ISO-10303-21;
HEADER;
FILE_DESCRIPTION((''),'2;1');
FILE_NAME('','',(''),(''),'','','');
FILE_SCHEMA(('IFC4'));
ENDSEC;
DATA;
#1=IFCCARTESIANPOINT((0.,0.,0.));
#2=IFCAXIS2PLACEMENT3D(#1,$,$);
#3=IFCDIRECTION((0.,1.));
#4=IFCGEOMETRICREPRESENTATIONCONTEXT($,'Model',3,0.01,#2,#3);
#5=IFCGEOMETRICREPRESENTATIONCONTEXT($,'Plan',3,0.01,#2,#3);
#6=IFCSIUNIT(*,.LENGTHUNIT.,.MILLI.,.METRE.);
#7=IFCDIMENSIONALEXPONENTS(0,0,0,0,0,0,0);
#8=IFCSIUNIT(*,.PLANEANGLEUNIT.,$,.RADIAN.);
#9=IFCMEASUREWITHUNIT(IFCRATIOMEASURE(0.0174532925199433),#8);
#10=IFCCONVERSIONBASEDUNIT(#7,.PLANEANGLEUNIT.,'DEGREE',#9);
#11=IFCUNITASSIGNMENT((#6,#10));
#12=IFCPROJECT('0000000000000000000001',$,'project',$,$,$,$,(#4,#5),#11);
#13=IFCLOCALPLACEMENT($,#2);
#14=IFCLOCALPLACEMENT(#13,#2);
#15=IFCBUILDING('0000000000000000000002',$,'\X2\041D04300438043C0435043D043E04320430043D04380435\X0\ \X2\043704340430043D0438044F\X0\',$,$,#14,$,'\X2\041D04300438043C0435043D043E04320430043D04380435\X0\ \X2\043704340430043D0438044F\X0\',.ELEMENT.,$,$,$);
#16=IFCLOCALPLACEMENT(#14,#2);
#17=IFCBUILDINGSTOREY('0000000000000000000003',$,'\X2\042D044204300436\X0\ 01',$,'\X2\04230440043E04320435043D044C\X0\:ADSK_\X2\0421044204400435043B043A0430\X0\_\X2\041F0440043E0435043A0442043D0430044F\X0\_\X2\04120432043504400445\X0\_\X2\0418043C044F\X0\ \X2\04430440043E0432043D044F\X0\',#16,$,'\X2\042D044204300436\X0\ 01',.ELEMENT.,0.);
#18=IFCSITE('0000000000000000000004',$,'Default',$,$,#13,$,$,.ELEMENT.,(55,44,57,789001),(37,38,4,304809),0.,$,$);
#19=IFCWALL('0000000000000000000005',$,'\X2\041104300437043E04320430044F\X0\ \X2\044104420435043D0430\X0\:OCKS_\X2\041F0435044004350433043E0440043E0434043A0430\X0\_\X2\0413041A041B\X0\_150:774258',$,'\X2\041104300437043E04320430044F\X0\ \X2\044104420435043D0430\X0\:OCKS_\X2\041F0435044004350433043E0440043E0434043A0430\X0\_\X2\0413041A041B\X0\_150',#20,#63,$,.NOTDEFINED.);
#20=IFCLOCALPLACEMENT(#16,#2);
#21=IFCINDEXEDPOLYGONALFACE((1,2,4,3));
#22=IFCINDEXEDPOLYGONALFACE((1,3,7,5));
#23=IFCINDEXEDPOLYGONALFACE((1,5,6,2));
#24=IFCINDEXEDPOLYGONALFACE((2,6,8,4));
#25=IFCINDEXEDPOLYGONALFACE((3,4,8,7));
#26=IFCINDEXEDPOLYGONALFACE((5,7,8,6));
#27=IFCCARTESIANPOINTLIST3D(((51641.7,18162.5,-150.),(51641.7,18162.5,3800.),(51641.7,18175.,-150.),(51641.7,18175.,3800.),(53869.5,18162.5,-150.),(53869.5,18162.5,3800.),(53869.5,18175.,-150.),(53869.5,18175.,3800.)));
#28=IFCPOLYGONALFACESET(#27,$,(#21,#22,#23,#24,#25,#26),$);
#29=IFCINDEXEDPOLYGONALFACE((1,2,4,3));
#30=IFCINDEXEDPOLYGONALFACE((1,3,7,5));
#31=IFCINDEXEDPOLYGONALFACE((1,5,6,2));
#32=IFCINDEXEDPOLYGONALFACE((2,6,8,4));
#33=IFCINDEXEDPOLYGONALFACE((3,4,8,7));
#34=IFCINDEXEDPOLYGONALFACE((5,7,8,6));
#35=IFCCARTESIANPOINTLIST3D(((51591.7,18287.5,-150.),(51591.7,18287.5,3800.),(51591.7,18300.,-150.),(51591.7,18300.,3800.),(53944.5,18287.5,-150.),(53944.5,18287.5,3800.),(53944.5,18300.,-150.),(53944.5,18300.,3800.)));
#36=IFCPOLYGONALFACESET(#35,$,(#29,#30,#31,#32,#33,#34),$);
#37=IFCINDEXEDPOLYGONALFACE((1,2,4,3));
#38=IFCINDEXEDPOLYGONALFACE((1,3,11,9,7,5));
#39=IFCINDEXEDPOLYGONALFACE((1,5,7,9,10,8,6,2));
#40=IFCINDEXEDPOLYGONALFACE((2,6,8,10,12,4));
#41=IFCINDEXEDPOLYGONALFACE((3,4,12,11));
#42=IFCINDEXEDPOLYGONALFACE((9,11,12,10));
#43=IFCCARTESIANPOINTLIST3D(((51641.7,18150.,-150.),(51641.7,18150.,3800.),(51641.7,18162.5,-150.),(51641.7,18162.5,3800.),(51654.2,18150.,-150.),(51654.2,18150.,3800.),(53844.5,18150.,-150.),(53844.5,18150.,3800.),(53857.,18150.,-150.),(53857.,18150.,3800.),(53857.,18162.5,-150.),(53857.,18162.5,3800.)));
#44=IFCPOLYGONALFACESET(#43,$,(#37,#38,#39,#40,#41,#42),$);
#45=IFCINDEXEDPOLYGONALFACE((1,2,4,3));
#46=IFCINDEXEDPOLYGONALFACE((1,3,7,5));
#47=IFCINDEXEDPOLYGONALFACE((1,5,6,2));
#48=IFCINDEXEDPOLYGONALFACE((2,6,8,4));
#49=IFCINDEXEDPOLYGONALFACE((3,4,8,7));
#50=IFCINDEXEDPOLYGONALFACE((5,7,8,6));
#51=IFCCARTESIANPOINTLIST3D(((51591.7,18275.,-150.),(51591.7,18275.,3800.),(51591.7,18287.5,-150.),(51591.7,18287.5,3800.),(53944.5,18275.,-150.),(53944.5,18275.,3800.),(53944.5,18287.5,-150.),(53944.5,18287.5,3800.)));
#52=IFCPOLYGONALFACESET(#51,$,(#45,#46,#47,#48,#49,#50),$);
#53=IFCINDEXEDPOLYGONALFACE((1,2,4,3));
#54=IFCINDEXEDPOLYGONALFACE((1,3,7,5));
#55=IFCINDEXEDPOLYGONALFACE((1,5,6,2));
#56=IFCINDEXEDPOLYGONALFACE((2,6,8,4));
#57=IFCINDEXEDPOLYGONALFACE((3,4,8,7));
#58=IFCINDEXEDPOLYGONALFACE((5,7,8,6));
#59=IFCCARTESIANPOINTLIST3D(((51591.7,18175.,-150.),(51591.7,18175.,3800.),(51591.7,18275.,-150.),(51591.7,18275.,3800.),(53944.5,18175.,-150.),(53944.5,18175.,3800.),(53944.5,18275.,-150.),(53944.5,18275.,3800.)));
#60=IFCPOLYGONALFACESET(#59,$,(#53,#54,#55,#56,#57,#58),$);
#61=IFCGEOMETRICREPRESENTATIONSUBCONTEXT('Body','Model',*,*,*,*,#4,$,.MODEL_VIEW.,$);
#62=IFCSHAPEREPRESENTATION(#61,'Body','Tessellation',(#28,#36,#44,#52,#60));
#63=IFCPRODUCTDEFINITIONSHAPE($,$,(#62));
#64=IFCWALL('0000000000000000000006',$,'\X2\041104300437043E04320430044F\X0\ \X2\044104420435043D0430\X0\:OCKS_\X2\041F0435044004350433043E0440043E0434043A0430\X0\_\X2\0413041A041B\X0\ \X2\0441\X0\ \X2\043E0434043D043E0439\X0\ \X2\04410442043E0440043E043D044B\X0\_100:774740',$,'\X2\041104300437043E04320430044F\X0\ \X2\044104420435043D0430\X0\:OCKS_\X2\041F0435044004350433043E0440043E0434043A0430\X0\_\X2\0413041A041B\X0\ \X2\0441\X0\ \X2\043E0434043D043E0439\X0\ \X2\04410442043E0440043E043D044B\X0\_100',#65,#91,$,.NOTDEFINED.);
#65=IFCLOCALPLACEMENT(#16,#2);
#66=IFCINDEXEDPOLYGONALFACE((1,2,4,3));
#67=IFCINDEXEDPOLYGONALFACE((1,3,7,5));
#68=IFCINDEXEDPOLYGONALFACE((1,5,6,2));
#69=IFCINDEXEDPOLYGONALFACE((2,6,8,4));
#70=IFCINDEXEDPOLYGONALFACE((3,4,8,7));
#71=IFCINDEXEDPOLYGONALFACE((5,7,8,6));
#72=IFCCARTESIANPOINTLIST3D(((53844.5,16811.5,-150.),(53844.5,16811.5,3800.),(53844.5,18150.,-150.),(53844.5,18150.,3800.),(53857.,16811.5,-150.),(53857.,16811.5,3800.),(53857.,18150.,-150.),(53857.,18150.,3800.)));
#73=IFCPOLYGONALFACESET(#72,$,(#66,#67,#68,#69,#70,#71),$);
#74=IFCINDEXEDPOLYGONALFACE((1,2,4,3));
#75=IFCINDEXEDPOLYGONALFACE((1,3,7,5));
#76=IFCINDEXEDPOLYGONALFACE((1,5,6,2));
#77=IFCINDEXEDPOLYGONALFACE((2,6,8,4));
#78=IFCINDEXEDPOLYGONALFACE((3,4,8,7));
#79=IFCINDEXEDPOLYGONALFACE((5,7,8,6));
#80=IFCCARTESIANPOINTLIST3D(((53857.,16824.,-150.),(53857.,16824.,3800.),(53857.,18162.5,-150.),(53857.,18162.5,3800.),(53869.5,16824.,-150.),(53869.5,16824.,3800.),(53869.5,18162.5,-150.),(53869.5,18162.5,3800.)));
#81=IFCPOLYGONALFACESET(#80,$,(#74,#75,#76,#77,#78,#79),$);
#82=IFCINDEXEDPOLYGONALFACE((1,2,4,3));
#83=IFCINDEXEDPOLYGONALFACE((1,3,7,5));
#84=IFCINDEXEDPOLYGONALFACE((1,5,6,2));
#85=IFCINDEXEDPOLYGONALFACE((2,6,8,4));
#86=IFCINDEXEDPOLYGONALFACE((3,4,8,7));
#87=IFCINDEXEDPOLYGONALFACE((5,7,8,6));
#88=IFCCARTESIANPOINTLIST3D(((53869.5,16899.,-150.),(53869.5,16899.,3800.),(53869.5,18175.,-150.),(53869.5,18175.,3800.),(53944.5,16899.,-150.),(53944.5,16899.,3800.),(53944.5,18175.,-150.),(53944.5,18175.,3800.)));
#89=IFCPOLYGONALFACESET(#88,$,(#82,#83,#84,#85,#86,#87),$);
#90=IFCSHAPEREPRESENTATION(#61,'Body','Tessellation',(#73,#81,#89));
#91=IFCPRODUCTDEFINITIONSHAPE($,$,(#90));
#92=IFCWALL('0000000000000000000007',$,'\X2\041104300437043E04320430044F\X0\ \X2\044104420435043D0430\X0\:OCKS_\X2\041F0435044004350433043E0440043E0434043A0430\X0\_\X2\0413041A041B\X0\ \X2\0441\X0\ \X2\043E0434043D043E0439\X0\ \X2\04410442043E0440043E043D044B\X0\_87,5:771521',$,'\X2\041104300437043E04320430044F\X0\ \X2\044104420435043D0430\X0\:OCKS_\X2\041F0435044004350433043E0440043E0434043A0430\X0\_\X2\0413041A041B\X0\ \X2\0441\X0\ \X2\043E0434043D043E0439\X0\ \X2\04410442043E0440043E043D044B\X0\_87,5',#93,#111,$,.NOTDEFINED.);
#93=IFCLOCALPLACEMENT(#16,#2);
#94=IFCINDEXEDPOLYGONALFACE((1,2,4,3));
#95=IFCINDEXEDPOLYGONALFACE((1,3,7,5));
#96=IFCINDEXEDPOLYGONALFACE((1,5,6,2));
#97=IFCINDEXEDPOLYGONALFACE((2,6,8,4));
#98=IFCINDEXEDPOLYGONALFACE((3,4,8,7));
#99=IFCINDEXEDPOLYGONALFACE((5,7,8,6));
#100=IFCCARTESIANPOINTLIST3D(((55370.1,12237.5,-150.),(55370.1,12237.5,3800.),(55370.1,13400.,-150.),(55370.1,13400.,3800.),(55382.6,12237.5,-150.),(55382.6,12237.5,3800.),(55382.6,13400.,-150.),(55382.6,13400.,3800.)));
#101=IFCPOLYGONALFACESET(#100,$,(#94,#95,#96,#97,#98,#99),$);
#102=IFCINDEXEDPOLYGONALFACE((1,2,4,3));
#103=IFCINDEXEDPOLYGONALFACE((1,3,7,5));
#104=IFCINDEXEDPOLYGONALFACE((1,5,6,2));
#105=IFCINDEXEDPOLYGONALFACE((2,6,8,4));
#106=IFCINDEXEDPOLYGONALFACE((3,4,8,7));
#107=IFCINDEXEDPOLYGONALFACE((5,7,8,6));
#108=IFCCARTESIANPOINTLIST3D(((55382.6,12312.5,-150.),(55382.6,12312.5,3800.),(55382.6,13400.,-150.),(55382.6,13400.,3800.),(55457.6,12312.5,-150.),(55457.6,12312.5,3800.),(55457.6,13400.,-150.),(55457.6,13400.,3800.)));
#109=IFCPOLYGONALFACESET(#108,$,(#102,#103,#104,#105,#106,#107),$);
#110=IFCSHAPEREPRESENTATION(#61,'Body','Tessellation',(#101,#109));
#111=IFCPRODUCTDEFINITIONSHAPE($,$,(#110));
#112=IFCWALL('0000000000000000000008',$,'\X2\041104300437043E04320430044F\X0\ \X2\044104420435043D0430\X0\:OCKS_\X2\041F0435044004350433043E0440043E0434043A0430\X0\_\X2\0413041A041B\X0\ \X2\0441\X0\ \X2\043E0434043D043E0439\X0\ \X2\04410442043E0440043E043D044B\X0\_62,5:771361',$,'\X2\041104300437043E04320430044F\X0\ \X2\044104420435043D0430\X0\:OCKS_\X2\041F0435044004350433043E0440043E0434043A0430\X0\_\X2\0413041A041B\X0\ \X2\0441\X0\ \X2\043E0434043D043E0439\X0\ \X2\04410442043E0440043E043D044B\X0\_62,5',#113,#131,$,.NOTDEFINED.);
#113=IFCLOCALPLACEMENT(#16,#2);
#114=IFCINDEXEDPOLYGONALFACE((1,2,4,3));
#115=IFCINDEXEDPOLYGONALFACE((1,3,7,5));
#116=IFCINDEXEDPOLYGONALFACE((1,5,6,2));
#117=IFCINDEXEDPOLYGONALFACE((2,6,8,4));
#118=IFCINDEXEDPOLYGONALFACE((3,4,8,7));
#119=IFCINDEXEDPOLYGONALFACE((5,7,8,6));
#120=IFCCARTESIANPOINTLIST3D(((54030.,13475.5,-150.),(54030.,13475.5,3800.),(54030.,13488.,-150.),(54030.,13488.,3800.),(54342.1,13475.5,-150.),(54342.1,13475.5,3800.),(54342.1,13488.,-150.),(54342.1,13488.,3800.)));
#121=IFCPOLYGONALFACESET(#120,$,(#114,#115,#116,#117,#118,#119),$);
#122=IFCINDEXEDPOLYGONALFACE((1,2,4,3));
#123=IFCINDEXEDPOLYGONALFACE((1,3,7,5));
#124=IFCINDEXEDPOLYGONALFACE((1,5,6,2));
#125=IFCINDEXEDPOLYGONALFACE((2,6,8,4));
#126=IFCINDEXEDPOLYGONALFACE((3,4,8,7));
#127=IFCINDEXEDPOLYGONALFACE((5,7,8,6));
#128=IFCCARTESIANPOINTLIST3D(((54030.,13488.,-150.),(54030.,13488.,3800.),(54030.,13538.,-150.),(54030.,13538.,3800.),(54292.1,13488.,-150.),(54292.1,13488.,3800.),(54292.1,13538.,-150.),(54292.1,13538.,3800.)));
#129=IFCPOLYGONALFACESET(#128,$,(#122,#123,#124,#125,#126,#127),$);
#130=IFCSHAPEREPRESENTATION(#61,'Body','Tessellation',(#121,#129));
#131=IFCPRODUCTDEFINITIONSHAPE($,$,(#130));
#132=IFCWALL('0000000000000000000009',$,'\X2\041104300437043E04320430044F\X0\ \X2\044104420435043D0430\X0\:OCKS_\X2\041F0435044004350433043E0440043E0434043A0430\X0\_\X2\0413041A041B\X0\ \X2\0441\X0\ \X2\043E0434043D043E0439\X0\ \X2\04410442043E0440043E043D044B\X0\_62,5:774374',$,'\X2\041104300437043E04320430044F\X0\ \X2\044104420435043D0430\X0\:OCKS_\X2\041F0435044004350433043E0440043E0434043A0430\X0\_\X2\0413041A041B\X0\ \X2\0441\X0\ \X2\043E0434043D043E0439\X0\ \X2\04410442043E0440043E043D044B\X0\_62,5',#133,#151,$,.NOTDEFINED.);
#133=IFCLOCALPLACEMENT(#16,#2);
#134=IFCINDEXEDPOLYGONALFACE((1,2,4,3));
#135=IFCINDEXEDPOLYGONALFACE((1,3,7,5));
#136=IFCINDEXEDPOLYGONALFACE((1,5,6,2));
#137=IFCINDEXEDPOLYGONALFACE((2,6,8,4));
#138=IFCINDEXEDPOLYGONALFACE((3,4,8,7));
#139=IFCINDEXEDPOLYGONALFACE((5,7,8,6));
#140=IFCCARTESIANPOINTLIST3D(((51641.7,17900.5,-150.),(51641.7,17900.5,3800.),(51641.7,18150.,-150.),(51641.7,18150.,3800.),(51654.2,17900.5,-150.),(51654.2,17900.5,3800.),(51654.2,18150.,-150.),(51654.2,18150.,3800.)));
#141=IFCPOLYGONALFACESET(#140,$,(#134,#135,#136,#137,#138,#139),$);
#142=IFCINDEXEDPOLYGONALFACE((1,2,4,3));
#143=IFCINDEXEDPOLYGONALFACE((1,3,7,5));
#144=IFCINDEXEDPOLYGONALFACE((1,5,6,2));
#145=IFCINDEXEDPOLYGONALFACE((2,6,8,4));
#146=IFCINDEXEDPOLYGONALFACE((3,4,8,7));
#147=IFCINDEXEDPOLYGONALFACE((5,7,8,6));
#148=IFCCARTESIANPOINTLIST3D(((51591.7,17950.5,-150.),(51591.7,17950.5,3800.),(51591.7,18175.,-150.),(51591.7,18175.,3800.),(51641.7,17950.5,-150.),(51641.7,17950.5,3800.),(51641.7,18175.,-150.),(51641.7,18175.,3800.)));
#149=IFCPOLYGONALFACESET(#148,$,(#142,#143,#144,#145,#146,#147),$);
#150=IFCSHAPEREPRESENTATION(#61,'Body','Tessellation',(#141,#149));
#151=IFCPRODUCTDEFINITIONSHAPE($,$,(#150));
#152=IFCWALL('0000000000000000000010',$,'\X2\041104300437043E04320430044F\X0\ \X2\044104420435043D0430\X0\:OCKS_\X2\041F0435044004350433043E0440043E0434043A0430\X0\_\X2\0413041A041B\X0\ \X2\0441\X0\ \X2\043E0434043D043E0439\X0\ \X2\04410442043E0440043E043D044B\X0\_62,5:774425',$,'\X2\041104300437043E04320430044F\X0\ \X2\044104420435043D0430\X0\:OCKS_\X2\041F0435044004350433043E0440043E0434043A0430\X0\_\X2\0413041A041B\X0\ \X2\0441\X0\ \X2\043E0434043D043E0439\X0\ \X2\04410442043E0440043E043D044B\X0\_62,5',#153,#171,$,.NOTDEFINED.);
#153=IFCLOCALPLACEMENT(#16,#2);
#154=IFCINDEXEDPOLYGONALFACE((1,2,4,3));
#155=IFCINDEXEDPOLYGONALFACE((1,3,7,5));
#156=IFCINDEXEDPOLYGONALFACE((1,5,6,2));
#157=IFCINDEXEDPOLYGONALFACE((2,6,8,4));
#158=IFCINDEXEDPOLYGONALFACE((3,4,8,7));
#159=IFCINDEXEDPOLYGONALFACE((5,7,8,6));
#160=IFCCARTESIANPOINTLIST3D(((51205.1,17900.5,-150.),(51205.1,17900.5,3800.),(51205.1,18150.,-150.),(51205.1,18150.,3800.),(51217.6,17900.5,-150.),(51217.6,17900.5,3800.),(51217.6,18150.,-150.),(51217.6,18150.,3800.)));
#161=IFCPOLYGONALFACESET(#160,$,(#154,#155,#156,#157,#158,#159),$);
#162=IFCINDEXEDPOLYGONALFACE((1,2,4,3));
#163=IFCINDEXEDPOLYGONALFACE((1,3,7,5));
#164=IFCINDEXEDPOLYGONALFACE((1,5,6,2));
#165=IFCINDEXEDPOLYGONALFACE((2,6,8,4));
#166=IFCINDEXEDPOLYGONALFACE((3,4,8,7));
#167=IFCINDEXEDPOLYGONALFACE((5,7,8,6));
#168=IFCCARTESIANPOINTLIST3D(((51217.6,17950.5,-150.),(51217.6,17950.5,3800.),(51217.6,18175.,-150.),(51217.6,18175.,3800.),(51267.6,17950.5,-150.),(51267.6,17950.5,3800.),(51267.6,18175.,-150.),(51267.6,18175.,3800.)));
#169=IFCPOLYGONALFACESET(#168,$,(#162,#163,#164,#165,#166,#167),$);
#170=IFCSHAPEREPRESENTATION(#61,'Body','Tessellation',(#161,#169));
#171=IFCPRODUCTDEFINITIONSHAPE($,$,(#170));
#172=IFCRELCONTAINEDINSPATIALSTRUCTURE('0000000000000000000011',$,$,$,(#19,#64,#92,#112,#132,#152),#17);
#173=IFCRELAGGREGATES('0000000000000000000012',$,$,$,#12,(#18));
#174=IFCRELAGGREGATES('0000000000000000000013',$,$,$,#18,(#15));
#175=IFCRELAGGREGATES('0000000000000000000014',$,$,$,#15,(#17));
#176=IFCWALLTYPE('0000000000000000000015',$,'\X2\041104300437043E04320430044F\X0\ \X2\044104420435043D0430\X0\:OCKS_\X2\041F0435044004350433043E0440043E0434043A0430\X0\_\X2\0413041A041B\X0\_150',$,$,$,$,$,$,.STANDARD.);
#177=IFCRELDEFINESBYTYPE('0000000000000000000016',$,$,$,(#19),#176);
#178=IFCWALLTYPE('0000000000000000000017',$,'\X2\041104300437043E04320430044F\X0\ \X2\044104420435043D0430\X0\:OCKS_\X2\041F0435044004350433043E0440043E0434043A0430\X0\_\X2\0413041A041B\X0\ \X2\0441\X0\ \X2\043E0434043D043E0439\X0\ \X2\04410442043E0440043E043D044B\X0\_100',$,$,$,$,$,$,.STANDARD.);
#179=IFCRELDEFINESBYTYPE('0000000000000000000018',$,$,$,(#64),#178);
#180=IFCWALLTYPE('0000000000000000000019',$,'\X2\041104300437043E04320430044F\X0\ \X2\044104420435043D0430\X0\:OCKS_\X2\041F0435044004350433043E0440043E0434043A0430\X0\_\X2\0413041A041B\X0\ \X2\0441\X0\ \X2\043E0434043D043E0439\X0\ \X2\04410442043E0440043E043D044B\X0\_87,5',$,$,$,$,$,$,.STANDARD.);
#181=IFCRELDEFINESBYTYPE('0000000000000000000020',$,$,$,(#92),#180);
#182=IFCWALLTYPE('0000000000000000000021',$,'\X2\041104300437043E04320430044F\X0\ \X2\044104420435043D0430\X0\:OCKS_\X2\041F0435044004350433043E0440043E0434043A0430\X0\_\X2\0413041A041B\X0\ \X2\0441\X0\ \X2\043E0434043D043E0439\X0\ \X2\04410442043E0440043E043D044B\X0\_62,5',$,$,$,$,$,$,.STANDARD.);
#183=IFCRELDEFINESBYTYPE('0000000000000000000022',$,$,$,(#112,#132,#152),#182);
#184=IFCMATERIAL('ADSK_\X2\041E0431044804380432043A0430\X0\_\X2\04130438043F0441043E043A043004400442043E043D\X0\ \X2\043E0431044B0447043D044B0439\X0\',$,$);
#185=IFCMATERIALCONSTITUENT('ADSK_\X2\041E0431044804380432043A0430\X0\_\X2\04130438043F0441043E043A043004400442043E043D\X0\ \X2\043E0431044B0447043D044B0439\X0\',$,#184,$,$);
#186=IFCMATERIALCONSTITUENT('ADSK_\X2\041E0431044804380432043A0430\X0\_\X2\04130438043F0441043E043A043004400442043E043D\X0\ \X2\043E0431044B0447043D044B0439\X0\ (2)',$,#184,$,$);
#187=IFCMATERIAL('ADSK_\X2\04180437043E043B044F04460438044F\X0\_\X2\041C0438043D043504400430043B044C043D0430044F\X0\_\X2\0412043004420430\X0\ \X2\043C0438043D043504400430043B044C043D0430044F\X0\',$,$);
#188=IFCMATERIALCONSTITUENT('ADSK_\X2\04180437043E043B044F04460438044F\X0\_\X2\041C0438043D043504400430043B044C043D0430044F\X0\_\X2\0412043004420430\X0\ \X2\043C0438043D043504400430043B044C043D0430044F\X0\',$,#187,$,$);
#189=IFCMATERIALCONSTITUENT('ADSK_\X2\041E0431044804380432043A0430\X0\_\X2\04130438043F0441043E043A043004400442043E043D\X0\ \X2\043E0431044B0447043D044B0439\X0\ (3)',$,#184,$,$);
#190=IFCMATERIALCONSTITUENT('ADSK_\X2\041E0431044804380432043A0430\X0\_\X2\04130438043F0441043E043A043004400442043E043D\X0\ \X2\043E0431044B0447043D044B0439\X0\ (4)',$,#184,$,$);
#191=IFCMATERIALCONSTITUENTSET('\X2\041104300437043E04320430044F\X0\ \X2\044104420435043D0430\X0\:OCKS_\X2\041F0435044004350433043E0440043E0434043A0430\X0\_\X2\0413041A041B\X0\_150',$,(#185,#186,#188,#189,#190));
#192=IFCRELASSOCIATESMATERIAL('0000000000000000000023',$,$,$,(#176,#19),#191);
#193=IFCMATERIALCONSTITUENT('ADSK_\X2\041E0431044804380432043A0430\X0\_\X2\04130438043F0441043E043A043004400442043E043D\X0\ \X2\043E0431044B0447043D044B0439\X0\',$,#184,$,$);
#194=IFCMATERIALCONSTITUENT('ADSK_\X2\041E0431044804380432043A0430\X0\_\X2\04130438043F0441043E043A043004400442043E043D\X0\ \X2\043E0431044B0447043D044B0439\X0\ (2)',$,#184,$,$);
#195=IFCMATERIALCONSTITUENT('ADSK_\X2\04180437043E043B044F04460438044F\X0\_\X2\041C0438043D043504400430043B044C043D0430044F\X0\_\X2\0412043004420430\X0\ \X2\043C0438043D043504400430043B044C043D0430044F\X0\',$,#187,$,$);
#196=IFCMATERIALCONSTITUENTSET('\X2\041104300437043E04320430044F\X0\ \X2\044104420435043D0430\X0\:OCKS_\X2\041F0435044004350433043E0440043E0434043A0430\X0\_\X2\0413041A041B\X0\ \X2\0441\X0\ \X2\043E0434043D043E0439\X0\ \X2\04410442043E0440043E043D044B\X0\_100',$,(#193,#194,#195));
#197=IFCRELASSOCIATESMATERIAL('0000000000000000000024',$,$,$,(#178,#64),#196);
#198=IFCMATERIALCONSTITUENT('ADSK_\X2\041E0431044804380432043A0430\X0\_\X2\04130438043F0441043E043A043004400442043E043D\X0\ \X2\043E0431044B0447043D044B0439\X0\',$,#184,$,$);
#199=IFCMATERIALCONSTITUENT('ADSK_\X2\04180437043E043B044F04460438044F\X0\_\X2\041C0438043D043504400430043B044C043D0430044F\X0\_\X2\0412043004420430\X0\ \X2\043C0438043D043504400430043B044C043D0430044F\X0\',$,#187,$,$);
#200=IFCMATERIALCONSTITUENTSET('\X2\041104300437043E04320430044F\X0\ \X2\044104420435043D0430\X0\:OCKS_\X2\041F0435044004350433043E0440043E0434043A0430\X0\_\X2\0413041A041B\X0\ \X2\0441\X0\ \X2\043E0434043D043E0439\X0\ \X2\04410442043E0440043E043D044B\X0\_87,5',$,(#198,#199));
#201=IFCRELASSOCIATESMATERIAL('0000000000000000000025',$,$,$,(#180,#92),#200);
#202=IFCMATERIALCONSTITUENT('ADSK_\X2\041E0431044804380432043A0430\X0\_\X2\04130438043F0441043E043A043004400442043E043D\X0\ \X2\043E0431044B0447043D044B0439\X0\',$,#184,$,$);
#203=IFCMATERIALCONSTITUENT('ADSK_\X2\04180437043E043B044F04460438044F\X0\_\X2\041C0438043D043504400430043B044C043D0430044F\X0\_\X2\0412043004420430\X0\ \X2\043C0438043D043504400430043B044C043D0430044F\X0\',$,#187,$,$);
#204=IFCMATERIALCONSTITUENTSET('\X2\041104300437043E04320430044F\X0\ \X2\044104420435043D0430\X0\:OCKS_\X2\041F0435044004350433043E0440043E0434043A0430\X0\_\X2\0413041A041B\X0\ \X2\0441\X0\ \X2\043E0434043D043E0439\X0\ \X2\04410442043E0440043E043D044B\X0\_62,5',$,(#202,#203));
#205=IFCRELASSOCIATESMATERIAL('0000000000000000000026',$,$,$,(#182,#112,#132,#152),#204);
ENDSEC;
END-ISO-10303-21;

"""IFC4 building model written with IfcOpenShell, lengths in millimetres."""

from ifc_helpers import new_model, entity, si_unit, converted_unit, direction, frame, origin, place, context, subcontext, project, spatial, indexed_curve, outline, extrude, material, constituent, constituent_set, type_object, element, save


model = new_model("IFC4")

# Units and contexts
model_context = context("Model", 3, precision=0.01, world=origin(), true_north=direction((0.0, 1.0)))
plan_context = context("Plan", 3, precision=0.01, world=origin(), true_north=direction((0.0, 1.0)))
body_context = subcontext(model_context, "Body", "Model", "MODEL_VIEW")
ifc_project = project(units=[si_unit("LENGTHUNIT", "METRE", prefix="MILLI"), converted_unit("PLANEANGLEUNIT", "DEGREE", entity("IfcRatioMeasure", 0.0174532925199433), si_unit("PLANEANGLEUNIT", "RADIAN"), dimensions=[0, 0, 0, 0, 0, 0, 0])], contexts=[model_context, plan_context])

# Site, building, storey
site_placement = place(None, frame((0.0, 0.0, 0.0)))
site = spatial("IfcSite", under=ifc_project, at=site_placement, Name="Default", CompositionType="ELEMENT", RefLatitude=(55, 44, 57, 789001), RefLongitude=(37, 38, 4, 304809), RefElevation=0.0)
building_placement = place(site_placement, origin())
building = spatial("IfcBuilding", under=site, at=building_placement, Name="Наименование здания", LongName="Наименование здания", CompositionType="ELEMENT")
storey_placement = place(building_placement, origin())
storey = spatial("IfcBuildingStorey", under=building, at=storey_placement, Name="Этаж 01", ObjectType="Уровень:ADSK_Стрелка_Проектная_Вверх_Имя уровня", LongName="Этаж 01", CompositionType="ELEMENT", Elevation=0.0)

# Shared definitions
ifc_material_1 = material(Name="ADSK_Обшивка_Гипсокартон обычный")
ifc_constituent_1 = constituent(ifc_material_1, Name="ADSK_Обшивка_Гипсокартон обычный")
ifc_constituent_2 = constituent(ifc_material_1, Name="ADSK_Обшивка_Гипсокартон обычный (2)")
ifc_material_2 = material(Name="ADSK_Изоляция_Минеральная_Вата минеральная")
ifc_constituent_3 = constituent(ifc_material_2, Name="ADSK_Изоляция_Минеральная_Вата минеральная")
ifc_constituent_4 = constituent(ifc_material_1, Name="ADSK_Обшивка_Гипсокартон обычный (3)")
ifc_constituent_5 = constituent(ifc_material_1, Name="ADSK_Обшивка_Гипсокартон обычный (4)")
ifc_constituent_set_1 = constituent_set(constituents=[ifc_constituent_1, ifc_constituent_2, ifc_constituent_3, ifc_constituent_4, ifc_constituent_5], Name="Базовая стена:OCKS_Перегородка_ГКЛ_150")
wall_type_1 = type_object("IfcWallType", Name="Базовая стена:OCKS_Перегородка_ГКЛ_150", PredefinedType="STANDARD", material=ifc_constituent_set_1)

# Walls
wall_1_placement = place(storey_placement, frame((51591.7, 18225.0, -150.0)))
element("IfcWall", 1, at=wall_1_placement, inside=storey, type_object=wall_type_1, material=ifc_constituent_set_1, Name="Базовая стена:OCKS_Перегородка_ГКЛ_150:774258", ObjectType="Базовая стена:OCKS_Перегородка_ГКЛ_150", PredefinedType="NOTDEFINED", context=body_context, shape_type="SweptSolid", body=[
    extrude(outline(indexed_curve([(-1113.9, -6.3), (1113.9, -6.3), (1113.9, 6.2), (-1113.9, 6.2), (-1113.9, -6.3)], self_intersect=False)), frame((1163.9, -56.2, 0.0)), (0.0, 0.0, 1.0), 3950.0),
    extrude(outline(indexed_curve([(-6.3, -1176.4), (6.2, -1176.4), (6.3, 1176.4), (-6.2, 1176.4), (-6.3, -1176.4)], self_intersect=False)), frame((1176.4, 68.8, 0.0), z_axis=(0.0, 0.0, 1.0), x_axis=(0.0, -1.0, 0.0)), (0.0, 0.0, 1.0), 3950.0),
    extrude(outline(indexed_curve([(-1095.2, -4.2), (1095.2, -4.2), (1107.7, -4.2), (1107.7, 8.3), (-1107.7, 8.3), (-1107.7, -4.2), (-1095.2, -4.2)], self_intersect=False)), frame((1157.7, -70.8, 0.0)), (0.0, 0.0, 1.0), 3950.0),
    extrude(outline(indexed_curve([(-1176.4, -6.3), (1176.4, -6.3), (1176.4, 6.2), (-1176.4, 6.2), (-1176.4, -6.3)], self_intersect=False)), frame((1176.4, 56.3, 0.0)), (0.0, 0.0, 1.0), 3950.0),
    extrude(outline(indexed_curve([(-1176.4, -50.0), (1176.4, -50.0), (1176.4, 50.0), (-1176.4, 50.0), (-1176.4, -50.0)], self_intersect=False)), frame((1176.4, 0.0, 0.0)), (0.0, 0.0, 1.0), 3950.0),
])
ifc_constituent_6 = constituent(ifc_material_1, Name="ADSK_Обшивка_Гипсокартон обычный")
ifc_constituent_7 = constituent(ifc_material_1, Name="ADSK_Обшивка_Гипсокартон обычный (2)")
ifc_constituent_8 = constituent(ifc_material_2, Name="ADSK_Изоляция_Минеральная_Вата минеральная")
ifc_constituent_set_2 = constituent_set(constituents=[ifc_constituent_6, ifc_constituent_7, ifc_constituent_8], Name="Базовая стена:OCKS_Перегородка_ГКЛ с одной стороны_100")
wall_type_2 = type_object("IfcWallType", Name="Базовая стена:OCKS_Перегородка_ГКЛ с одной стороны_100", PredefinedType="STANDARD", material=ifc_constituent_set_2)
wall_2_placement = place(storey_placement, frame((53894.5, 16899.0, -150.0), z_axis=(0.0, 0.0, 1.0), x_axis=(0.0, 1.0, 0.0)))
element("IfcWall", 2, at=wall_2_placement, inside=storey, type_object=wall_type_2, material=ifc_constituent_set_2, Name="Базовая стена:OCKS_Перегородка_ГКЛ с одной стороны_100:774740", ObjectType="Базовая стена:OCKS_Перегородка_ГКЛ с одной стороны_100", PredefinedType="NOTDEFINED", context=body_context, shape_type="SweptSolid", body=[
    extrude(outline(indexed_curve([(-6.3, -669.3), (6.2, -669.3), (6.2, 669.3), (-6.3, 669.3), (-6.3, -669.3)], self_intersect=False)), frame((581.8, 43.7, 0.0), z_axis=(0.0, 0.0, 1.0), x_axis=(0.0, -1.0, 0.0)), (0.0, 0.0, 1.0), 3950.0),
    extrude(outline(indexed_curve([(-669.3, -6.2), (669.3, -6.2), (669.3, 6.3), (-669.3, 6.3), (-669.3, -6.2)], self_intersect=False)), frame((594.3, 31.2, 0.0)), (0.0, 0.0, 1.0), 3950.0),
    extrude(outline(indexed_curve([(-37.5, -638.0), (37.5, -638.0), (37.5, 638.0), (-37.5, 638.0), (-37.5, -638.0)], self_intersect=False)), frame((638.0, -12.5, 0.0), z_axis=(0.0, 0.0, 1.0), x_axis=(0.0, 1.0, 0.0)), (0.0, 0.0, 1.0), 3950.0),
])
ifc_constituent_9 = constituent(ifc_material_1, Name="ADSK_Обшивка_Гипсокартон обычный")
ifc_constituent_10 = constituent(ifc_material_2, Name="ADSK_Изоляция_Минеральная_Вата минеральная")
ifc_constituent_set_3 = constituent_set(constituents=[ifc_constituent_9, ifc_constituent_10], Name="Базовая стена:OCKS_Перегородка_ГКЛ с одной стороны_87,5")
wall_type_3 = type_object("IfcWallType", Name="Базовая стена:OCKS_Перегородка_ГКЛ с одной стороны_87,5", PredefinedType="STANDARD", material=ifc_constituent_set_3)
wall_3_placement = place(storey_placement, frame((55413.9, 12312.5, -150.0), z_axis=(0.0, 0.0, 1.0), x_axis=(0.0, 1.0, 0.0)))
element("IfcWall", 3, at=wall_3_placement, inside=storey, type_object=wall_type_3, material=ifc_constituent_set_3, Name="Базовая стена:OCKS_Перегородка_ГКЛ с одной стороны_87,5:771521", ObjectType="Базовая стена:OCKS_Перегородка_ГКЛ с одной стороны_87,5", PredefinedType="NOTDEFINED", context=body_context, shape_type="SweptSolid", body=[
    extrude(outline(indexed_curve([(-6.3, -581.2), (6.3, -581.2), (6.3, 581.2), (-6.3, 581.2), (-6.3, -581.2)], self_intersect=False)), frame((506.2, 37.5, 0.0), z_axis=(0.0, 0.0, 1.0), x_axis=(0.0, -1.0, 0.0)), (0.0, 0.0, 1.0), 3950.0),
    extrude(outline(indexed_curve([(-37.5, -543.8), (37.5, -543.8), (37.5, 543.8), (-37.5, 543.8), (-37.5, -543.8)], self_intersect=False)), frame((543.8, -6.2, 0.0), z_axis=(0.0, 0.0, 1.0), x_axis=(0.0, 1.0, 0.0)), (0.0, 0.0, 1.0), 3950.0),
])
ifc_constituent_11 = constituent(ifc_material_1, Name="ADSK_Обшивка_Гипсокартон обычный")
ifc_constituent_12 = constituent(ifc_material_2, Name="ADSK_Изоляция_Минеральная_Вата минеральная")
ifc_constituent_set_4 = constituent_set(constituents=[ifc_constituent_11, ifc_constituent_12], Name="Базовая стена:OCKS_Перегородка_ГКЛ с одной стороны_62,5")
wall_type_4 = type_object("IfcWallType", Name="Базовая стена:OCKS_Перегородка_ГКЛ с одной стороны_62,5", PredefinedType="STANDARD", material=ifc_constituent_set_4)
wall_4_placement = place(storey_placement, frame((54292.1, 13506.8, -150.0), z_axis=(0.0, 0.0, 1.0), x_axis=(-1.0, 0.0, 0.0)))
element("IfcWall", 4, at=wall_4_placement, inside=storey, type_object=wall_type_4, material=ifc_constituent_set_4, Name="Базовая стена:OCKS_Перегородка_ГКЛ с одной стороны_62,5:771361", ObjectType="Базовая стена:OCKS_Перегородка_ГКЛ с одной стороны_62,5", PredefinedType="NOTDEFINED", context=body_context, shape_type="SweptSolid", body=[
    extrude(outline(indexed_curve([(-6.2, -156.1), (6.3, -156.1), (6.3, 156.1), (-6.2, 156.1), (-6.2, -156.1)], self_intersect=False)), frame((106.1, 25.0, 0.0), z_axis=(0.0, 0.0, 1.0), x_axis=(0.0, -1.0, 0.0)), (0.0, 0.0, 1.0), 3950.0),
    extrude(outline(indexed_curve([(-25.0, -131.1), (25.0, -131.1), (25.0, 131.1), (-25.0, 131.1), (-25.0, -131.1)], self_intersect=False)), frame((131.1, -6.3, 0.0), z_axis=(0.0, 0.0, 1.0), x_axis=(0.0, 1.0, 0.0)), (0.0, 0.0, 1.0), 3950.0),
])
wall_5_placement = place(storey_placement, frame((51622.9, 17950.5, -150.0), z_axis=(0.0, 0.0, 1.0), x_axis=(0.0, 1.0, 0.0)))
element("IfcWall", 5, at=wall_5_placement, inside=storey, type_object=wall_type_4, material=ifc_constituent_set_4, Name="Базовая стена:OCKS_Перегородка_ГКЛ с одной стороны_62,5:774374", ObjectType="Базовая стена:OCKS_Перегородка_ГКЛ с одной стороны_62,5", PredefinedType="NOTDEFINED", context=body_context, shape_type="SweptSolid", body=[
    extrude(outline(indexed_curve([(-6.3, -124.7), (6.2, -124.7), (6.3, 124.7), (-6.2, 124.7), (-6.3, -124.7)], self_intersect=False)), frame((74.7, -25.0, 0.0), z_axis=(0.0, 0.0, 1.0), x_axis=(0.0, 1.0, 0.0)), (0.0, 0.0, 1.0), 3950.0),
    extrude(outline(indexed_curve([(-25.0, -112.2), (25.0, -112.2), (25.0, 112.2), (-25.0, 112.2), (-25.0, -112.2)], self_intersect=False)), frame((112.2, 6.2, 0.0), z_axis=(0.0, 0.0, 1.0), x_axis=(0.0, -1.0, 0.0)), (0.0, 0.0, 1.0), 3950.0),
])
wall_6_placement = place(storey_placement, frame((51236.4, 17950.5, -150.0), z_axis=(0.0, 0.0, 1.0), x_axis=(0.0, 1.0, 0.0)))
element("IfcWall", 6, at=wall_6_placement, inside=storey, type_object=wall_type_4, material=ifc_constituent_set_4, Name="Базовая стена:OCKS_Перегородка_ГКЛ с одной стороны_62,5:774425", ObjectType="Базовая стена:OCKS_Перегородка_ГКЛ с одной стороны_62,5", PredefinedType="NOTDEFINED", context=body_context, shape_type="SweptSolid", body=[
    extrude(outline(indexed_curve([(-6.2, -124.7), (6.3, -124.7), (6.3, 124.7), (-6.2, 124.7), (-6.2, -124.7)], self_intersect=False)), frame((74.7, 25.0, 0.0), z_axis=(0.0, 0.0, 1.0), x_axis=(0.0, -1.0, 0.0)), (0.0, 0.0, 1.0), 3950.0),
    extrude(outline(indexed_curve([(-25.0, -112.2), (25.0, -112.2), (25.0, 112.2), (-25.0, 112.2), (-25.0, -112.2)], self_intersect=False)), frame((112.2, -6.3, 0.0), z_axis=(0.0, 0.0, 1.0), x_axis=(0.0, 1.0, 0.0)), (0.0, 0.0, 1.0), 3950.0),
])

save(model, "model.ifc")
